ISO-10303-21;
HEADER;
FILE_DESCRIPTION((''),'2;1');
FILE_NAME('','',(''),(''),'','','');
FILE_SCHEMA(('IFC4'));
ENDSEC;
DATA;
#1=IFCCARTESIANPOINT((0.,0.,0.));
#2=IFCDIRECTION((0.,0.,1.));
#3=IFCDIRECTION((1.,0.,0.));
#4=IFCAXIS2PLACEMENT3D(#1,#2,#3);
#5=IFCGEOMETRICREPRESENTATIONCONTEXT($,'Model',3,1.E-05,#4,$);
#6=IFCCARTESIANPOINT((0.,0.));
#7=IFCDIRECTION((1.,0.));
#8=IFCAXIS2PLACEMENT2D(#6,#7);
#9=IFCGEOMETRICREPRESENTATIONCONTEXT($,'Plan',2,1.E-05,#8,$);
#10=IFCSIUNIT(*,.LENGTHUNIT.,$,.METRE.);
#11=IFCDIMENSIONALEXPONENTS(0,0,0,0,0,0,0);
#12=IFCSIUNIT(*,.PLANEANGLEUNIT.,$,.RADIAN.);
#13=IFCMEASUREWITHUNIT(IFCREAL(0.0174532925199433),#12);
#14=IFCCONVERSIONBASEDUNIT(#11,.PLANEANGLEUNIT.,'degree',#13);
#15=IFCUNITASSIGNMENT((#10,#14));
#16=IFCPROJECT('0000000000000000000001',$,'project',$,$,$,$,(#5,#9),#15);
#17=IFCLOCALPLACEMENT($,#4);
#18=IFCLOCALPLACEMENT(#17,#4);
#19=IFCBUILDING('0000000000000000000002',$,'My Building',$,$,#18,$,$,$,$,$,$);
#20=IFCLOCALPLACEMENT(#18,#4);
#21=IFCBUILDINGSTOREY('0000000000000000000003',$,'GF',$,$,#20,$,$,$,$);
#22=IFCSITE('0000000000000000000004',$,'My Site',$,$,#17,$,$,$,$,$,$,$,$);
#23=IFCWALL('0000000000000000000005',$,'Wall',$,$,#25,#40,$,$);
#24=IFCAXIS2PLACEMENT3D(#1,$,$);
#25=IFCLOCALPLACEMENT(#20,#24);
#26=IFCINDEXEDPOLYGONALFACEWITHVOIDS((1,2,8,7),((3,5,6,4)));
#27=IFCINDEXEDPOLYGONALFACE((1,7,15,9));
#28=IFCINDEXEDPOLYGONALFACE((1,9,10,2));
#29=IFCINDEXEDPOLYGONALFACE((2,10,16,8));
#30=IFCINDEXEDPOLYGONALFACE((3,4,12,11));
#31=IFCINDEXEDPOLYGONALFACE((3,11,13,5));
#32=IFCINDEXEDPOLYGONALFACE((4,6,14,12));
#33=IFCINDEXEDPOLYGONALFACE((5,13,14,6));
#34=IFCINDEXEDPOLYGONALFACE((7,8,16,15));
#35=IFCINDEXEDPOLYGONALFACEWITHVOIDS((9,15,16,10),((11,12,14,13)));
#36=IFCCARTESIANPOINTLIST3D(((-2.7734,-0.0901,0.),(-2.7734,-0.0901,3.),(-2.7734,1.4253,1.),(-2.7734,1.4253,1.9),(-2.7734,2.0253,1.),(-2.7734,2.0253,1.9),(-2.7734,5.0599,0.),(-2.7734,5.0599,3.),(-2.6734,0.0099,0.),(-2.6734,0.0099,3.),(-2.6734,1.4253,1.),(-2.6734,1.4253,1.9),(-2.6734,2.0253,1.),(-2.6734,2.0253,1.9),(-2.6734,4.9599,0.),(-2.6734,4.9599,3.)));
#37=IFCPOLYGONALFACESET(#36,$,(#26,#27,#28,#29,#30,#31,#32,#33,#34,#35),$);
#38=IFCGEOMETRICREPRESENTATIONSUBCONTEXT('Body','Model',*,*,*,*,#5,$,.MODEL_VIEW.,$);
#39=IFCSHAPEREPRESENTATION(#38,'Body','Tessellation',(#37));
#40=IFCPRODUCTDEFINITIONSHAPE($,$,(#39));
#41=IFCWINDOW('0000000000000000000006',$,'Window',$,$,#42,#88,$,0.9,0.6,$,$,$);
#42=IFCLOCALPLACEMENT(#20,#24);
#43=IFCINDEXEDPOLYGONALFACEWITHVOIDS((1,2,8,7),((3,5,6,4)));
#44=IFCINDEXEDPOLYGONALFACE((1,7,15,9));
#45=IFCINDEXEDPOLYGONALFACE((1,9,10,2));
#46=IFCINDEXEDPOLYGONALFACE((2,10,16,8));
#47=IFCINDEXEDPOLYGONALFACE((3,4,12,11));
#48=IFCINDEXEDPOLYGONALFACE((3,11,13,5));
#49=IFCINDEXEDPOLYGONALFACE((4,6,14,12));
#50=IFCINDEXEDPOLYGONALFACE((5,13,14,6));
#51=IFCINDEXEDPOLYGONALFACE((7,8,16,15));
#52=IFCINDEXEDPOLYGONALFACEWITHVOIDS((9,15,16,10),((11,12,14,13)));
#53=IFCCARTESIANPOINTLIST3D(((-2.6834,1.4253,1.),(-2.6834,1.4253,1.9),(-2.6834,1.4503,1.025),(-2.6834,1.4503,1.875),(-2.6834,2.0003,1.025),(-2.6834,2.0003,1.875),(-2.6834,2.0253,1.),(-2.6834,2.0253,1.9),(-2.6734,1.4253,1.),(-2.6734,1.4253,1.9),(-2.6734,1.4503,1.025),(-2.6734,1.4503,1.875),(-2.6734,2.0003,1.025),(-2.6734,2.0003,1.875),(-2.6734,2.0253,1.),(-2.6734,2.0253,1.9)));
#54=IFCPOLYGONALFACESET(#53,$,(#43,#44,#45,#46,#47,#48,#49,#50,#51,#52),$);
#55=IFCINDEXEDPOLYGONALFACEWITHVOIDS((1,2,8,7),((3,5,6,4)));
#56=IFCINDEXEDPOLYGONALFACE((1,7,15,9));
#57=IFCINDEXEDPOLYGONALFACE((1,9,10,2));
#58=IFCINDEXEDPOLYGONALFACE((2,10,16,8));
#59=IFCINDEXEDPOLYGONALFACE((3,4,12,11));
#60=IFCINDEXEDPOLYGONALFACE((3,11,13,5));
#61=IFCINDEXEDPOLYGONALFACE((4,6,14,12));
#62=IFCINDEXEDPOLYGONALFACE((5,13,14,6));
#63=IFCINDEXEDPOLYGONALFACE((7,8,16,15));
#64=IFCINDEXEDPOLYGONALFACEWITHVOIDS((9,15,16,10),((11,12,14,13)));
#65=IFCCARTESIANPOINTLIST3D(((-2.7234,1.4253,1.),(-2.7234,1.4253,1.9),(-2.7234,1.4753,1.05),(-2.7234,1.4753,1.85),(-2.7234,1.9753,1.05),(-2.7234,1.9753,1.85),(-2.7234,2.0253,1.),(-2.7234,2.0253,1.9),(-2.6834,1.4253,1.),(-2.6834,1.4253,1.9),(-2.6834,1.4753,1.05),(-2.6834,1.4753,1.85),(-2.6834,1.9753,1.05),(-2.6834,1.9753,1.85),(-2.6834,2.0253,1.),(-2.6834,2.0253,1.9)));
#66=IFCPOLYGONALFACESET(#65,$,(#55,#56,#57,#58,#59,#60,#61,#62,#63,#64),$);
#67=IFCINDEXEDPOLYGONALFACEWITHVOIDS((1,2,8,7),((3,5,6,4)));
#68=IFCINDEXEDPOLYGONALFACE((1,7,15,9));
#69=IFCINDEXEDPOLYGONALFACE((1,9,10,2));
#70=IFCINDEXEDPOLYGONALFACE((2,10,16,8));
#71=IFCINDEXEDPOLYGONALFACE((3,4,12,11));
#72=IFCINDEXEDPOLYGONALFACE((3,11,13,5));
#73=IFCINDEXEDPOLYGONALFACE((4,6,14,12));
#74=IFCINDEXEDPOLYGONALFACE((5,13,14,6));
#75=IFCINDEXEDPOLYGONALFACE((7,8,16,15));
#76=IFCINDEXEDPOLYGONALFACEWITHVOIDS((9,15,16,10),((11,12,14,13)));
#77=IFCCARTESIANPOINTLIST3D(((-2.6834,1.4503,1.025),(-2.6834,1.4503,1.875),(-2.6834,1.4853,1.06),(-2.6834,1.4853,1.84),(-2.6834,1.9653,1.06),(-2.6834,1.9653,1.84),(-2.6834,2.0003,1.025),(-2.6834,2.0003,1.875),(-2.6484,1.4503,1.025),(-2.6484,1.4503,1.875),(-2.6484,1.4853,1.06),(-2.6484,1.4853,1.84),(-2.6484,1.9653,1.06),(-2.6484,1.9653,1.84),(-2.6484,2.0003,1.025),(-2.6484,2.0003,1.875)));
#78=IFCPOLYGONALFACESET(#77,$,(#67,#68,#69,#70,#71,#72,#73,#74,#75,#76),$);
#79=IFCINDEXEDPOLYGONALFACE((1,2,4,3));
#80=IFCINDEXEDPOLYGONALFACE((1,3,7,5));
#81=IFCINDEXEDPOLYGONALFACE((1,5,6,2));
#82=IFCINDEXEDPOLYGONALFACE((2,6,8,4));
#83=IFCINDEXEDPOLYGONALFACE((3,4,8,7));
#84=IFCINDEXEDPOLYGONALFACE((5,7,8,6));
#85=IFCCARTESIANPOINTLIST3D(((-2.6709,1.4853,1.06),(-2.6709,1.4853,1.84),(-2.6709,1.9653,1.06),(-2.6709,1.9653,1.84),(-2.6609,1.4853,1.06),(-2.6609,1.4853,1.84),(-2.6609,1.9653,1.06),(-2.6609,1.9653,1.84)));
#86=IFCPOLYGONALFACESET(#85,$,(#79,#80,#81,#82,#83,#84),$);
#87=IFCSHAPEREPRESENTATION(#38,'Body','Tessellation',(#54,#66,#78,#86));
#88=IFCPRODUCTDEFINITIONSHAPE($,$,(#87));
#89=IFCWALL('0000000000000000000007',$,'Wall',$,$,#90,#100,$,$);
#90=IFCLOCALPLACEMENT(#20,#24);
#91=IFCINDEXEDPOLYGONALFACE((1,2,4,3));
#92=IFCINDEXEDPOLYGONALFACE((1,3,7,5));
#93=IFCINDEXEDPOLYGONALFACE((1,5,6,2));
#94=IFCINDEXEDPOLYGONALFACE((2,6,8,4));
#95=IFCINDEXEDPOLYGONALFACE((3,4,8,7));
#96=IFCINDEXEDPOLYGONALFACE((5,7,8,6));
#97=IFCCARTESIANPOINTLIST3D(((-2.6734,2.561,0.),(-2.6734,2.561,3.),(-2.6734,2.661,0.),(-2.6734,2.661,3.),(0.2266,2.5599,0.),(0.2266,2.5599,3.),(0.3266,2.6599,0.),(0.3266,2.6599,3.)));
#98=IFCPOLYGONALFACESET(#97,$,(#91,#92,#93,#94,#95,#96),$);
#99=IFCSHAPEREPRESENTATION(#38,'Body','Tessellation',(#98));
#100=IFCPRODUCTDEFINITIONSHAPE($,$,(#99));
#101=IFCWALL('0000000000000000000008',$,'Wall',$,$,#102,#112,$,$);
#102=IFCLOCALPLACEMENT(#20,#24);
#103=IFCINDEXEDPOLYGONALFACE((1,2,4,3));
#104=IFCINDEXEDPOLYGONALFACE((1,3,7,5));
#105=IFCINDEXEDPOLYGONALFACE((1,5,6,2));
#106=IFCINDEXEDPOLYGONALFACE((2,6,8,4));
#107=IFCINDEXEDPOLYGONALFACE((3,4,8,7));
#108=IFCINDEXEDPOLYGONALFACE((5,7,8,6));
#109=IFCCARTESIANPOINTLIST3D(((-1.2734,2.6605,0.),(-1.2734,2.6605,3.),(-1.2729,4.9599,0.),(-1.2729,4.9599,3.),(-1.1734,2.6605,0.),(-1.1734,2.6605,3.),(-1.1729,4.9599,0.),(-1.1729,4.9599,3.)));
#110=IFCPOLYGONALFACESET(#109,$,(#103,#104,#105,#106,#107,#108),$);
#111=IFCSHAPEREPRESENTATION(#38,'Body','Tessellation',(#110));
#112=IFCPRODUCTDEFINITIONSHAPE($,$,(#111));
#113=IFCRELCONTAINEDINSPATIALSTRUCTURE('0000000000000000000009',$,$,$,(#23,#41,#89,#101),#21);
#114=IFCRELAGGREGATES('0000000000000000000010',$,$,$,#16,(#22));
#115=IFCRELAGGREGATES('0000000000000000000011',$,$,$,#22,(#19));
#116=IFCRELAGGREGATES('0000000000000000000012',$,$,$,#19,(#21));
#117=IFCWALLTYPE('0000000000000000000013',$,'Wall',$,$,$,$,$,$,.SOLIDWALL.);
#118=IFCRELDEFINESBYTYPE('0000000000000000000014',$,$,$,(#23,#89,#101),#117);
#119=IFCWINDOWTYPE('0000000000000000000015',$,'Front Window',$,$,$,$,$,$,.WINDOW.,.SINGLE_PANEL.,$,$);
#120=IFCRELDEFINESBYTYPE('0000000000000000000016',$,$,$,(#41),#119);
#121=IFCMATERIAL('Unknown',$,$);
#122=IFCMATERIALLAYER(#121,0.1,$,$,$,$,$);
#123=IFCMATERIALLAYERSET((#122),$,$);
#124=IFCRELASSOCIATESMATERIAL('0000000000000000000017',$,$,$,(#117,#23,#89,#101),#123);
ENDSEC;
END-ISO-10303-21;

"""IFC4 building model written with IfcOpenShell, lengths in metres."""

from ifc_helpers import new_model, entity, si_unit, converted_unit, frame, origin_with_axes, origin_2d_with_axis, place, context, subcontext, project, spatial, line, indexed_curve, outline, extrude, shape, source, transform, mapped, material, layer, layer_set, layer_usage, type_object, type_shapes, element, fill, save


model = new_model("IFC4")

# Units and contexts
model_context = context("Model", 3, precision=1e-05, world=origin_with_axes())
plan_context = context("Plan", 2, precision=1e-05, world=origin_2d_with_axis())
body_context_1 = subcontext(model_context, "Body", "Model", "MODEL_VIEW")
body_context_2 = subcontext(plan_context, "Body", "Plan", "PLAN_VIEW")
ifc_project = project(units=[si_unit("LENGTHUNIT", "METRE"), converted_unit("PLANEANGLEUNIT", "degree", entity("IfcReal", 0.0174532925199433), si_unit("PLANEANGLEUNIT", "RADIAN"), dimensions=[0, 0, 0, 0, 0, 0, 0])], contexts=[model_context, plan_context])

# Site, building, storey
site_placement = place(None, origin_with_axes())
site = spatial("IfcSite", under=ifc_project, at=site_placement, Name="My Site")
building_placement = place(site_placement, origin_with_axes())
building = spatial("IfcBuilding", under=site, at=building_placement, Name="My Building")
storey_placement = place(building_placement, origin_with_axes())
storey = spatial("IfcBuildingStorey", under=building, at=storey_placement, Name="GF")

# Shared definitions
ifc_material_1 = material(Name="Unknown")

# Shared definitions
ifc_layer_1 = layer(ifc_material_1, 0.1)
ifc_layer_set_1 = layer_set([ifc_layer_1])
wall_type = type_object("IfcWallType", Name="Wall", PredefinedType="SOLIDWALL", material=ifc_layer_set_1)

# Wall, opening, window
ifc_layer_usage_1 = layer_usage(ifc_layer_set_1, "AXIS2", "POSITIVE", 0.0)
wall_1_placement = place(storey_placement, frame((-2.7734, 5.0599, 0.0), z_axis=(0.0, 0.0, 1.0), x_axis=(0.0, -1.0, 0.0)))
wall_1 = element("IfcWall", 1, at=wall_1_placement, inside=storey, type_object=wall_type, material=ifc_layer_usage_1, Name="Wall", context=body_context_1, shape_type="SweptSolid", body=[
    extrude(outline(indexed_curve([(0.0, 0.0), (0.1, 0.1), (5.05, 0.1), (5.15, 0.0)], segments=[line(1, 2, 3, 4, 1)])), origin_with_axes(), (0.0, 0.0, 1.0), 3.0),
])
shared_shape_1 = source(origin_with_axes(), body_context_1, "Body", "SweptSolid", [
    extrude(outline(indexed_curve([(0.0, 0.0), (0.6, 0.0), (0.6, 0.9), (0.0, 0.9)], segments=[line(1, 2, 3, 4, 1)])), frame((0.0, -0.6, 0.0), z_axis=(0.0, -1.0, 0.0), x_axis=(1.0, 0.0, 0.0)), (0.0, 0.0, -1.0), 1.2),
])
opening_1_placement = place(wall_1_placement, frame((3.0346, 0.0, 1.0), z_axis=(0.0, 0.0, 1.0), x_axis=(1.0, 0.0, 0.0)))
opening_1 = element("IfcOpeningElement", 2, at=opening_1_placement, cuts=wall_1, PredefinedType="OPENING", context=body_context_1, shape_type="MappedRepresentation", body=[
    mapped(shared_shape_1, transform((0.0, 0.0, 0.0), x_axis=(1.0, 0.0, 0.0), y_axis=(0.0, 1.0, 0.0), z_axis=(0.0, 0.0, 1.0), scale=1.0)),
])
window_type_1 = type_object("IfcWindowType", Name="Front Window", PartitioningType="SINGLE_PANEL", PredefinedType="WINDOW")
shared_shape_2 = source(origin_with_axes(), body_context_1, "Body", "SweptSolid", [
    extrude(outline(indexed_curve([(0.0, 0.0), (0.6, 0.0), (0.6, 0.9), (0.0, 0.9)], segments=[line(1, 2, 3, 4, 1)]), holes=[indexed_curve([(0.025, 0.025), (0.575, 0.025), (0.575, 0.875), (0.025, 0.875)], segments=[line(1, 2, 3, 4, 1)])]), frame((0.0, 0.09, 0.0), z_axis=(0.0, -1.0, 0.0), x_axis=(1.0, 0.0, 0.0)), (0.0, 0.0, -1.0), 0.01),
    extrude(outline(indexed_curve([(0.0, 0.0), (0.6, 0.0), (0.6, 0.9), (0.0, 0.9)], segments=[line(1, 2, 3, 4, 1)]), holes=[indexed_curve([(0.05, 0.05), (0.55, 0.05), (0.55, 0.85), (0.05, 0.85)], segments=[line(1, 2, 3, 4, 1)])]), frame((0.0, 0.05, 0.0), z_axis=(0.0, -1.0, 0.0), x_axis=(1.0, 0.0, 0.0)), (0.0, 0.0, -1.0), 0.04),
    extrude(outline(indexed_curve([(0.0, 0.0), (0.55, 0.0), (0.55, 0.85), (0.0, 0.85)], segments=[line(1, 2, 3, 4, 1)]), holes=[indexed_curve([(0.035, 0.035), (0.515, 0.035), (0.515, 0.815), (0.035, 0.815)], segments=[line(1, 2, 3, 4, 1)])]), frame((0.025, 0.09, 0.025), z_axis=(0.0, -1.0, 0.0), x_axis=(1.0, 0.0, 0.0)), (0.0, 0.0, -1.0), 0.035),
    extrude(outline(indexed_curve([(0.035, 0.035), (0.515, 0.035), (0.515, 0.815), (0.035, 0.815)], segments=[line(1, 2, 3, 4, 1)])), frame((0.025, 0.1025, 0.025), z_axis=(0.0, -1.0, 0.0), x_axis=(1.0, 0.0, 0.0)), (0.0, 0.0, -1.0), 0.01),
])
shared_shape_3 = source(origin_with_axes(), body_context_2, "Body", "Curve2D", [
    entity("IfcIndexedPolyCurve", entity("IfcCartesianPointList2D", [[0.05, 0.05], [0.55, 0.05]])),
    entity("IfcIndexedPolyCurve", entity("IfcCartesianPointList2D", [[0.0, 0.1], [0.025, 0.1], [0.025, 0.09], [0.05, 0.09], [0.05, 0.05], [0.0, 0.05]]), [entity("IfcLineIndex", [1, 2, 3, 4, 5, 6, 1])]),
    entity("IfcIndexedPolyCurve", entity("IfcCartesianPointList2D", [[0.6, 0.1], [0.575, 0.1], [0.575, 0.09], [0.55, 0.09], [0.55, 0.05], [0.6, 0.05]]), [entity("IfcLineIndex", [1, 2, 3, 4, 5, 6, 1])]),
    entity("IfcIndexedPolyCurve", entity("IfcCartesianPointList2D", [[0.025, 0.09], [0.06, 0.09], [0.06, 0.125], [0.025, 0.125]]), [entity("IfcLineIndex", [1, 2, 3, 4, 1])]),
    entity("IfcIndexedPolyCurve", entity("IfcCartesianPointList2D", [[0.575, 0.09], [0.54, 0.09], [0.54, 0.125], [0.575, 0.125]]), [entity("IfcLineIndex", [1, 2, 3, 4, 1])]),
    entity("IfcIndexedPolyCurve", entity("IfcCartesianPointList2D", [[0.06, 0.09], [0.54, 0.09]])),
    entity("IfcIndexedPolyCurve", entity("IfcCartesianPointList2D", [[0.06, 0.125], [0.54, 0.125]])),
    entity("IfcIndexedPolyCurve", entity("IfcCartesianPointList2D", [[0.06, 0.1075], [0.54, 0.1075]])),
])
type_shapes(window_type_1, [shared_shape_2, shared_shape_3])
window_1_placement = place(opening_1_placement, frame((0.0, 0.0, 0.0), z_axis=(0.0, 0.0, 1.0), x_axis=(1.0, 0.0, 0.0)))
window_1 = element("IfcWindow", 3, at=window_1_placement, inside=storey, type_object=window_type_1, Name="Window", OverallHeight=0.9, OverallWidth=0.6, shapes=[
    shape(body_context_1, "Body", "MappedRepresentation", [mapped(shared_shape_2, transform((0.0, 0.0, 0.0), x_axis=(1.0, 0.0, 0.0), y_axis=(0.0, 1.0, 0.0), z_axis=(0.0, 0.0, 1.0), scale=1.0))]),
    shape(body_context_2, "Body", "MappedRepresentation", [mapped(shared_shape_3, transform((0.0, 0.0, 0.0), x_axis=(1.0, 0.0, 0.0), y_axis=(0.0, 1.0, 0.0), z_axis=(0.0, 0.0, 1.0), scale=1.0))]),
])
fill(opening_1, window_1)

# Walls
ifc_layer_usage_2 = layer_usage(ifc_layer_set_1, "AXIS2", "POSITIVE", 0.0)
wall_2_placement = place(storey_placement, frame((0.3266, 2.6599, 0.0), z_axis=(0.0, 0.0, 1.0), x_axis=(-1.0, 0.000381, 0.0)))
element("IfcWall", 4, at=wall_2_placement, inside=storey, type_object=wall_type, material=ifc_layer_usage_2, Name="Wall", context=body_context_1, shape_type="SweptSolid", body=[
    extrude(outline(indexed_curve([(0.0, 0.0), (0.1, 0.1), (3.0, 0.1), (3.0, 0.0)], segments=[line(1, 2, 3, 4, 1)])), origin_with_axes(), (0.0, 0.0, 1.0), 3.0),
])
ifc_layer_usage_3 = layer_usage(ifc_layer_set_1, "AXIS2", "POSITIVE", 0.0)
wall_3_placement = place(storey_placement, frame((-1.1734, 2.6605, 0.0), z_axis=(0.0, 0.0, 1.0), x_axis=(0.000197, 1.0, 0.0)))
element("IfcWall", 5, at=wall_3_placement, inside=storey, type_object=wall_type, material=ifc_layer_usage_3, Name="Wall", context=body_context_1, shape_type="SweptSolid", body=[
    extrude(outline(indexed_curve([(0.0, 0.0), (0.0, 0.1), (2.2994, 0.1), (2.2994, 0.0)], segments=[line(1, 2, 3, 4, 1)])), origin_with_axes(), (0.0, 0.0, 1.0), 3.0),
])

save(model, "model.ifc")
